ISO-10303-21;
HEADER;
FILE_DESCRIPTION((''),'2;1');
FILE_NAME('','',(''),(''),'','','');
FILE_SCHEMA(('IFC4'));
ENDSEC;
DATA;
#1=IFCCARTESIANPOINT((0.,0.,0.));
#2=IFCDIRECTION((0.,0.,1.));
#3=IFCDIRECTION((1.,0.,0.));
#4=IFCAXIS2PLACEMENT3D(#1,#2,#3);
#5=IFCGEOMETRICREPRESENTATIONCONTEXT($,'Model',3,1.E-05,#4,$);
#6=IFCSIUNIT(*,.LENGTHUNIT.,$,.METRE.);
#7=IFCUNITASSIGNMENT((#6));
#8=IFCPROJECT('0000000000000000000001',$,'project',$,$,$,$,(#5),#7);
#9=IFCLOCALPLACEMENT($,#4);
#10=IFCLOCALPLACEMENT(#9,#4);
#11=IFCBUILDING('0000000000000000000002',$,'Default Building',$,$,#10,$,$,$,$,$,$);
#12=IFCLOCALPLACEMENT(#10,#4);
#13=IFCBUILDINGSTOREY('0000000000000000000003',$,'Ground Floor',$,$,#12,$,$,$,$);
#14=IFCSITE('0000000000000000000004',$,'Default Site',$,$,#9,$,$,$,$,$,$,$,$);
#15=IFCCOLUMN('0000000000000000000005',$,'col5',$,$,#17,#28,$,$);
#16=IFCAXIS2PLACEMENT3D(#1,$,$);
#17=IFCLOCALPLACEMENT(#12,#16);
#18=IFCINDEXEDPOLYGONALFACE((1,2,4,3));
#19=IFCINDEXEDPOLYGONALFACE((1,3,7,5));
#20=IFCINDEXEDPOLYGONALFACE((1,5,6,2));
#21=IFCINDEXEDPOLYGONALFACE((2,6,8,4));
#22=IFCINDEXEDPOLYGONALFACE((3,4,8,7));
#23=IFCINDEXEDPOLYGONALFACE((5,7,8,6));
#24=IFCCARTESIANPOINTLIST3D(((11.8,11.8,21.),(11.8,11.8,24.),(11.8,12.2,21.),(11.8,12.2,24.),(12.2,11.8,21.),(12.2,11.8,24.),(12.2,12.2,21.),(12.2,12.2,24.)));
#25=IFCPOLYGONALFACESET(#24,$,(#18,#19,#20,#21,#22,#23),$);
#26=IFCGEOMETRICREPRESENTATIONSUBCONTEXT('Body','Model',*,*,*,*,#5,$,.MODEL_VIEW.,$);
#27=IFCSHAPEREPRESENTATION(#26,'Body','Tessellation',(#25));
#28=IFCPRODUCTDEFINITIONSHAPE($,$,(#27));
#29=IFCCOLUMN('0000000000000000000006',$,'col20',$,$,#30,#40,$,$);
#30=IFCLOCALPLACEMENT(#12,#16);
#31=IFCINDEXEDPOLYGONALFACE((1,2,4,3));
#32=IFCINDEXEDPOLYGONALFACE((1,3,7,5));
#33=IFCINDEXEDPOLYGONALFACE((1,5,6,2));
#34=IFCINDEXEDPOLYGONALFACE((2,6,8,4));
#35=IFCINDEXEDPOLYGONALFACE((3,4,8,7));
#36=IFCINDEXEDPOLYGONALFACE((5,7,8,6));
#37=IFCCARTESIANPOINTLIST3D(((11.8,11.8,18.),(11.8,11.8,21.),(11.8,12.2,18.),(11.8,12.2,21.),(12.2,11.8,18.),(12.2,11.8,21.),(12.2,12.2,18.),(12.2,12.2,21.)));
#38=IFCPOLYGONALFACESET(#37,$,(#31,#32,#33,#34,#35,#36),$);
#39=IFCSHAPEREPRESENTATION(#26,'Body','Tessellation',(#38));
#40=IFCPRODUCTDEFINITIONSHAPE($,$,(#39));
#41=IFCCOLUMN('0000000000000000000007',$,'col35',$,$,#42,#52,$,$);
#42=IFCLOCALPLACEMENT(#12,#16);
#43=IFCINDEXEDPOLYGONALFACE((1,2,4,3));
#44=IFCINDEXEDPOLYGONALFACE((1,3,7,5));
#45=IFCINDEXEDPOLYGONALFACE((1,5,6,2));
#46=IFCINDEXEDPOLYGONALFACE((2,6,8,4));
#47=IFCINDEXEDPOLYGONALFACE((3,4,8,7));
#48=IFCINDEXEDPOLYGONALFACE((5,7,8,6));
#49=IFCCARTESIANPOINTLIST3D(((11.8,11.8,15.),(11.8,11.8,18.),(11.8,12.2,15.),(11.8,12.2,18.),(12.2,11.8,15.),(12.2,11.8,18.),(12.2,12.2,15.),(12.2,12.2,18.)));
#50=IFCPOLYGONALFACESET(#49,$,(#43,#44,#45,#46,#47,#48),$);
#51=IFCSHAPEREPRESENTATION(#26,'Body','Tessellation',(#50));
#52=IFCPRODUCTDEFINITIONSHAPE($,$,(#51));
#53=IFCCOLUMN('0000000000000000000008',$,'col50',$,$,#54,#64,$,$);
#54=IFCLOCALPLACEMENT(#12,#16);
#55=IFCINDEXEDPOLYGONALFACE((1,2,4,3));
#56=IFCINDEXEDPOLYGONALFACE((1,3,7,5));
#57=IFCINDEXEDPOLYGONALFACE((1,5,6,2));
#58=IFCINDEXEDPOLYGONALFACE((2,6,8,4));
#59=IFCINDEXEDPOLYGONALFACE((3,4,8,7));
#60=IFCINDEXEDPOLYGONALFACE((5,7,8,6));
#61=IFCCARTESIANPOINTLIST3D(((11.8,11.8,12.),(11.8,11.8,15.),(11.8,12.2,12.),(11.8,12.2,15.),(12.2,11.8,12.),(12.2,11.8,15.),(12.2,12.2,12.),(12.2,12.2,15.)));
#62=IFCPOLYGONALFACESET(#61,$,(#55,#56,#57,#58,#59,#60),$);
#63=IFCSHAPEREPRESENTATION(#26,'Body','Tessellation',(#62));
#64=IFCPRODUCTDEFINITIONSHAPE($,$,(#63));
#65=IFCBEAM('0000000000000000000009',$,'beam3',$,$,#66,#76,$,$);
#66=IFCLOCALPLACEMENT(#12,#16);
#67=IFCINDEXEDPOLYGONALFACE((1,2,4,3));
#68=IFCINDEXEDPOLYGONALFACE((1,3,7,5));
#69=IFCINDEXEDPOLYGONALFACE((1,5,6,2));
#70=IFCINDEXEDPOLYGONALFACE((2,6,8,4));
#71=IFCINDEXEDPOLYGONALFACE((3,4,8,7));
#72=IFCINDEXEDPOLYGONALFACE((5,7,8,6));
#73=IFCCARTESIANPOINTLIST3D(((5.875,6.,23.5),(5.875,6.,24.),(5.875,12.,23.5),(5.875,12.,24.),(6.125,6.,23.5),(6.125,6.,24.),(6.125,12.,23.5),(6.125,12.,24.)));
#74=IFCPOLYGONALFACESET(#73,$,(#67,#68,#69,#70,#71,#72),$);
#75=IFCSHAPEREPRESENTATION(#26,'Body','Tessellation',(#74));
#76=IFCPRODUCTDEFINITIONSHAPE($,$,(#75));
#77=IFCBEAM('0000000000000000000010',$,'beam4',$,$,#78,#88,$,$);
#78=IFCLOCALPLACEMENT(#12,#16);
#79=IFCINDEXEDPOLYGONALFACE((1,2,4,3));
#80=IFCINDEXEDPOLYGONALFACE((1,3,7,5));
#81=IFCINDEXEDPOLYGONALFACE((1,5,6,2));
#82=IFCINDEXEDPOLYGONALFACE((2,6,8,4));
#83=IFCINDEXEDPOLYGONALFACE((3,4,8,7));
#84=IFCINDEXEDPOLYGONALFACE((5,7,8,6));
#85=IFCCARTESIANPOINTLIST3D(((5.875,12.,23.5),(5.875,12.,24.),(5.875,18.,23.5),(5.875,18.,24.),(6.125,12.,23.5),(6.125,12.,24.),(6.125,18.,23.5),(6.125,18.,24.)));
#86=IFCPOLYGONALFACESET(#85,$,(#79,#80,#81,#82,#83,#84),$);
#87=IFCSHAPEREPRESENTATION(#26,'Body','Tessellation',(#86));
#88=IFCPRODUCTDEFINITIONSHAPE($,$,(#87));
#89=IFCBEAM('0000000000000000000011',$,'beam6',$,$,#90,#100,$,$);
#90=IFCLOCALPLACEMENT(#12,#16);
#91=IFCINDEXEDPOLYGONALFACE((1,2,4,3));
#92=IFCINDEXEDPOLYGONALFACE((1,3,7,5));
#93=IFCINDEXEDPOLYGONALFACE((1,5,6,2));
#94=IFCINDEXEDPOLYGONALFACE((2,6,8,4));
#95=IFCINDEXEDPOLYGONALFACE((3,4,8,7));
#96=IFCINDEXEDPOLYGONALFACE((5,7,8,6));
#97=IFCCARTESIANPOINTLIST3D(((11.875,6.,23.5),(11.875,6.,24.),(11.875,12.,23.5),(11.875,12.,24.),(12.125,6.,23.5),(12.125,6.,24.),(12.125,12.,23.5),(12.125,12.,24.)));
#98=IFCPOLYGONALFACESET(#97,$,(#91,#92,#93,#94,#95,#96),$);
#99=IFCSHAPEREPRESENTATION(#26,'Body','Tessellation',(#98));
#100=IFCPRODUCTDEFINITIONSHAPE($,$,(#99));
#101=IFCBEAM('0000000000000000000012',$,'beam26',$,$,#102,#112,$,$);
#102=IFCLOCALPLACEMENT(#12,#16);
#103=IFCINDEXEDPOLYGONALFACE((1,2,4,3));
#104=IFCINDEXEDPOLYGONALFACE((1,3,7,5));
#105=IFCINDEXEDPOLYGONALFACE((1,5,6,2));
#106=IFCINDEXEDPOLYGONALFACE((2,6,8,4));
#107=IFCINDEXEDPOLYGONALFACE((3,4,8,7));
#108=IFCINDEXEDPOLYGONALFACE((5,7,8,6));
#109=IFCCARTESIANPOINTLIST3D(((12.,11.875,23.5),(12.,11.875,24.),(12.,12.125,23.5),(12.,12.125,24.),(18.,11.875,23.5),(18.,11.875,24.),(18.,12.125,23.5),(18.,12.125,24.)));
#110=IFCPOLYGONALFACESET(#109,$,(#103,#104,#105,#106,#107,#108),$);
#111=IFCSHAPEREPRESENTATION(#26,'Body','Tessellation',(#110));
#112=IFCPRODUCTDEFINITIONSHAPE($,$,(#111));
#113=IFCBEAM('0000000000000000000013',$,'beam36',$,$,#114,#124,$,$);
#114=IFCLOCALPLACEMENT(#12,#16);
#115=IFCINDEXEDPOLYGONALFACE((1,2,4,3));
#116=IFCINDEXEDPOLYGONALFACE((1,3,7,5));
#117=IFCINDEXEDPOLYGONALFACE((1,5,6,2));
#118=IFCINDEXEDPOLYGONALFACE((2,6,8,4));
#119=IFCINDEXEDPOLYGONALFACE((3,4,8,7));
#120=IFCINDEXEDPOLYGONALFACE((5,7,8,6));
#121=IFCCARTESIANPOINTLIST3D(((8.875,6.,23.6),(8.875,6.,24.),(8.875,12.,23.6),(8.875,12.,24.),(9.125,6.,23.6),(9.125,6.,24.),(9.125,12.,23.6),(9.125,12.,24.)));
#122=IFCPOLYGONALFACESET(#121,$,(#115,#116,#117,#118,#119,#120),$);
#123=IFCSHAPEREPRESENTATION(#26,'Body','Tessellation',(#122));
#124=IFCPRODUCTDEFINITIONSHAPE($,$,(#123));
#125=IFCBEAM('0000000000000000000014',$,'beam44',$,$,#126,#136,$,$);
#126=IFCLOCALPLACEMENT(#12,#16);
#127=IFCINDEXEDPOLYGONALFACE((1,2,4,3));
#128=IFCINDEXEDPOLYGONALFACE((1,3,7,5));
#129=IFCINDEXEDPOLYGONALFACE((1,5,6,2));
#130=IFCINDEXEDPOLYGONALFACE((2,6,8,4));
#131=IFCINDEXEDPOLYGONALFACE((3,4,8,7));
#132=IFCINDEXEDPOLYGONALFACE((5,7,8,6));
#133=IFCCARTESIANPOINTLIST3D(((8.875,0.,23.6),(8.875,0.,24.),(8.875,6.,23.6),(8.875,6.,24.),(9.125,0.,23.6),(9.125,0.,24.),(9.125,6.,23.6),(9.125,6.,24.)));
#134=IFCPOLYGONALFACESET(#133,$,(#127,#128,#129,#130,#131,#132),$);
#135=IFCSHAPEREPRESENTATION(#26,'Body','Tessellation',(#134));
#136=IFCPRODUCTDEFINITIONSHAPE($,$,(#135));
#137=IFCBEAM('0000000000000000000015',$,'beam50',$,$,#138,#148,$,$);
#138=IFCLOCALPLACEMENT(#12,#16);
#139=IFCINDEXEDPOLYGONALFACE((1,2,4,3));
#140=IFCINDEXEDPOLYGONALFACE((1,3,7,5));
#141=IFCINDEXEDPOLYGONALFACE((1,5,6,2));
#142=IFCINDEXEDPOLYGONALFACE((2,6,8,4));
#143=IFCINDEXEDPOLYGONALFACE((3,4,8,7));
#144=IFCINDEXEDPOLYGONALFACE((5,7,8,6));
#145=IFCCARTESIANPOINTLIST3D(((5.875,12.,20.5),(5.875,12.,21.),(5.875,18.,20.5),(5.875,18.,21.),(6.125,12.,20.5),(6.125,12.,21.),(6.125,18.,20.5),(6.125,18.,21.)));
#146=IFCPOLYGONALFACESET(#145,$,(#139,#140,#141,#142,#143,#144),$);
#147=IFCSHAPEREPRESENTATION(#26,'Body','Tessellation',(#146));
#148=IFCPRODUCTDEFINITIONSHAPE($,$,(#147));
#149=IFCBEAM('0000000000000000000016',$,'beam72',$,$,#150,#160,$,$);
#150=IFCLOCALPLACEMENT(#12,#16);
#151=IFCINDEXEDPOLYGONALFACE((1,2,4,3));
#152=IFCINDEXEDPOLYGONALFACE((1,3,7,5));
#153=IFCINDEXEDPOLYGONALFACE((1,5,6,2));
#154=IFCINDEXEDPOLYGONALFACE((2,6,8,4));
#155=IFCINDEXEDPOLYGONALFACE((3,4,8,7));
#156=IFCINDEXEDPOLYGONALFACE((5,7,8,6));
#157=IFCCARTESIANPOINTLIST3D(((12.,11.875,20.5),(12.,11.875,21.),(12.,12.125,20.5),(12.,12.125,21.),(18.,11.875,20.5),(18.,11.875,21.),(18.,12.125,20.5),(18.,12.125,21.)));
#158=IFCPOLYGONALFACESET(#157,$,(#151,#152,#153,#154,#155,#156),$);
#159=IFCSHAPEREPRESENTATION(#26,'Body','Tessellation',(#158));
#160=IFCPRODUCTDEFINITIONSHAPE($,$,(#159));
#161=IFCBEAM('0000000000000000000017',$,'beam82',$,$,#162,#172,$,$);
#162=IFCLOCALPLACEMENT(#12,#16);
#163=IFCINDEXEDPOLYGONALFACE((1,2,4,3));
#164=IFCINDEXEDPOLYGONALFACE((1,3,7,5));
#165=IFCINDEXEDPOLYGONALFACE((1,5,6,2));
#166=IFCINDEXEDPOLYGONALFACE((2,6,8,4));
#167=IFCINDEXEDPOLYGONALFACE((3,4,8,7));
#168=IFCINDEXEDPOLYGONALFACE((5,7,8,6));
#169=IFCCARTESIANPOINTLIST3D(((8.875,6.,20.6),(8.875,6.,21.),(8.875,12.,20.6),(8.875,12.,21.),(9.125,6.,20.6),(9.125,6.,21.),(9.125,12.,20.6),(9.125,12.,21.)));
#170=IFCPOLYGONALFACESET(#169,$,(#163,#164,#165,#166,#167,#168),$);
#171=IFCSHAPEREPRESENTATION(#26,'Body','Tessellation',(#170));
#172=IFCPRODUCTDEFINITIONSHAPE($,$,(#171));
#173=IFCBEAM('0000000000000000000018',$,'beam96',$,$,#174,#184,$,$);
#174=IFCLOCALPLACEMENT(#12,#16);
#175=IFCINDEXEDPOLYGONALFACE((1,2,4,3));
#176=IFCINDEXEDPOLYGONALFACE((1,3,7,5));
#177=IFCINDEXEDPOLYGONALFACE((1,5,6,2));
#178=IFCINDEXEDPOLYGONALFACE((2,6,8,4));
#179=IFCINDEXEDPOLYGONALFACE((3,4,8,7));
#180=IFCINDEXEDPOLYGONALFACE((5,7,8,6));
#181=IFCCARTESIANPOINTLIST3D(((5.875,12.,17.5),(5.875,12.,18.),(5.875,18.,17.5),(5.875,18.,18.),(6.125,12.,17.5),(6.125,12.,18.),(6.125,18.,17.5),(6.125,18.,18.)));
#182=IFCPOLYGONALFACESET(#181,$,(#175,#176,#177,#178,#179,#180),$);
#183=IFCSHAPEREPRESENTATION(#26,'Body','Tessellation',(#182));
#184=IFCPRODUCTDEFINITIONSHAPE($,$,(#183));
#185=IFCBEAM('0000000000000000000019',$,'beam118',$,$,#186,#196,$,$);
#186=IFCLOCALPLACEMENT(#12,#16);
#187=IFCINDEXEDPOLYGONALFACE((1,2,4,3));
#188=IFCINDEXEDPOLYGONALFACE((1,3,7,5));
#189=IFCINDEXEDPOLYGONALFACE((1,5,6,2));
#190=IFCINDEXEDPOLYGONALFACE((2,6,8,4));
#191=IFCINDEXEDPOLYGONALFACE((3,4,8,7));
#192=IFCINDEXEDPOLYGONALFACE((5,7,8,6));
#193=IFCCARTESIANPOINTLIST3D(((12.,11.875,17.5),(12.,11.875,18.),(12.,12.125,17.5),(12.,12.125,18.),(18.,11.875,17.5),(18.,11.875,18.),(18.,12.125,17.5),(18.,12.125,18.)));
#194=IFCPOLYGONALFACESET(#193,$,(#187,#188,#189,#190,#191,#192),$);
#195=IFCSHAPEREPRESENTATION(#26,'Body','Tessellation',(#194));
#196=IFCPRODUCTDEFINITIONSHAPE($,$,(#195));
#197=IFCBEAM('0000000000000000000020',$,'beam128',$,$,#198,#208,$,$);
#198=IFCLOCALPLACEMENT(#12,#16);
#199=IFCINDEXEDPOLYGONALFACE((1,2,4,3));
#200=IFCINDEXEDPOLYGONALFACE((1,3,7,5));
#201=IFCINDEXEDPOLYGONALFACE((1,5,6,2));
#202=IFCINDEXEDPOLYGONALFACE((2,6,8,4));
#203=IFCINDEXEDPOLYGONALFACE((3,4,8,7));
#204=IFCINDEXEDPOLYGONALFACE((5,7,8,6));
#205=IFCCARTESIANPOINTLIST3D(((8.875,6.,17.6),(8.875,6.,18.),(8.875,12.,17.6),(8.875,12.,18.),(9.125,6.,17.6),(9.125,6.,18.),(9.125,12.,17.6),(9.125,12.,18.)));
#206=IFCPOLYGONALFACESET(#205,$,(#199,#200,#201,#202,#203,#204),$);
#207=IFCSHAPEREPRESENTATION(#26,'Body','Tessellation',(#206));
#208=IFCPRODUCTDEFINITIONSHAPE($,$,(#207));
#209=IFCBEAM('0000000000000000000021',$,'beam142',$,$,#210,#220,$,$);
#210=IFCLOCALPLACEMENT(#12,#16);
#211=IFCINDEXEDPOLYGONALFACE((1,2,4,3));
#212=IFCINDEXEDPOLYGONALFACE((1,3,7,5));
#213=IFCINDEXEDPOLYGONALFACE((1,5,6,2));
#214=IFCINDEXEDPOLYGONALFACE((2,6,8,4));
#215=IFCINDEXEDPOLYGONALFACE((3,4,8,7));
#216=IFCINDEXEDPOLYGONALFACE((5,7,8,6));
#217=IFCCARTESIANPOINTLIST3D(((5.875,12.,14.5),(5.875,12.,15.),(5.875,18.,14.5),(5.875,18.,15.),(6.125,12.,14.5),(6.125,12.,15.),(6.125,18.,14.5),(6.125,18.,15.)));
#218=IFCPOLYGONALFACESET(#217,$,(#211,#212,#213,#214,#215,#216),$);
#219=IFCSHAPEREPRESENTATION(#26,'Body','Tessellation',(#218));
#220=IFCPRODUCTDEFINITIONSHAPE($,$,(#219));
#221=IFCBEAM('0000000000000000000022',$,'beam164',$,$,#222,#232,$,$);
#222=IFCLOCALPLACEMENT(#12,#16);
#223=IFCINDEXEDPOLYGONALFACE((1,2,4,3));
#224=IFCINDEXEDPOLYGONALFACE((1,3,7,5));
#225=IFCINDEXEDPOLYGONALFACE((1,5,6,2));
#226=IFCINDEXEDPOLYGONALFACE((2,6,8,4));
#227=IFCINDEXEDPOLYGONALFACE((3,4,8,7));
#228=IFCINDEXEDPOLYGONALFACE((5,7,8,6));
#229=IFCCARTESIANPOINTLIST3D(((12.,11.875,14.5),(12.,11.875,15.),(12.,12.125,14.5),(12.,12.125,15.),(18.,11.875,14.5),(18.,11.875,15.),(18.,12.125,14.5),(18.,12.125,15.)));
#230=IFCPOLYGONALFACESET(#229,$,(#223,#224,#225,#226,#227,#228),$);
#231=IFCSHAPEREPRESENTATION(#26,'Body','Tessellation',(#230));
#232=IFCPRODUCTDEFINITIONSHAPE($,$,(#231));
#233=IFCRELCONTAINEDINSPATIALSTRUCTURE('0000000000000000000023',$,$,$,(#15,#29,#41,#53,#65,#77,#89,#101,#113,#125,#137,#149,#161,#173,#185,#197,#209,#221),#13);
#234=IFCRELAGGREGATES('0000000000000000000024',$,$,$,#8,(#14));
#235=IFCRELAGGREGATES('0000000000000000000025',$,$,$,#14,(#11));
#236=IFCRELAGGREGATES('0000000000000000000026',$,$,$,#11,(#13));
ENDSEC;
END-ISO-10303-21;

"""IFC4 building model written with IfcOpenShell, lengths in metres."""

from ifc_helpers import new_model, si_unit, frame, origin_with_axes, place, context, subcontext, project, spatial, indexed_curve, outline, extrude, element, save


model = new_model("IFC4")

# Units and contexts
model_context = context("Model", 3, precision=1e-05, world=origin_with_axes())
body_context = subcontext(model_context, "Body", "Model", "MODEL_VIEW")
ifc_project = project(units=[si_unit("LENGTHUNIT", "METRE")], contexts=[model_context])

# Site, building, storey
site_placement = place(None, origin_with_axes())
site = spatial("IfcSite", under=ifc_project, at=site_placement, Name="Default Site")
building_placement = place(site_placement, origin_with_axes())
building = spatial("IfcBuilding", under=site, at=building_placement, Name="Default Building")
storey_placement = place(building_placement, origin_with_axes())
storey = spatial("IfcBuildingStorey", under=building, at=storey_placement, Name="Ground Floor")

# Columns
for number, where, z_axis, x_axis, name in (
    (1, (11.8, 11.8, 21.0), (0.0, 0.0, 1.0), (1.0, 0.0, 0.0), "col5"),
    (2, (11.8, 11.8, 18.0), (0.0, 0.0, 1.0), (1.0, 0.0, 0.0), "col20"),
    (3, (11.8, 11.8, 15.0), (0.0, 0.0, 1.0), (1.0, 0.0, 0.0), "col35"),
    (4, (11.8, 11.8, 12.0), (0.0, 0.0, 1.0), (1.0, 0.0, 0.0), "col50"),
):
    element("IfcColumn", number, at=place(storey_placement, frame(where, z_axis=z_axis, x_axis=x_axis)), inside=storey, Name=name, context=body_context, shape_type="SweptSolid", body=[
        extrude(outline(indexed_curve([(0.0, 0.0), (0.0, 0.4), (0.4, 0.4), (0.4, 0.0), (0.0, 0.0)], self_intersect=False)), origin_with_axes(), (0.0, 0.0, 1.0), 3.0),
    ])

# Beams
for number, where, z_axis, x_axis, name in (
    (5, (6.125, 6.0, 23.5), (0.0, 0.0, 1.0), (0.0, 1.0, 0.0), "beam3"),
    (6, (6.125, 12.0, 23.5), (0.0, 0.0, 1.0), (0.0, 1.0, 0.0), "beam4"),
    (7, (12.125, 6.0, 23.5), (0.0, 0.0, 1.0), (0.0, 1.0, 0.0), "beam6"),
    (8, (12.0, 11.875, 23.5), (0.0, 0.0, 1.0), (1.0, 0.0, 0.0), "beam26"),
):
    element("IfcBeam", number, at=place(storey_placement, frame(where, z_axis=z_axis, x_axis=x_axis)), inside=storey, Name=name, context=body_context, shape_type="SweptSolid", body=[
        extrude(outline(indexed_curve([(0.0, 0.0), (0.0, 0.25), (6.0, 0.25), (6.0, 0.0), (0.0, 0.0)], self_intersect=False)), origin_with_axes(), (0.0, 0.0, 1.0), 0.5),
    ])
for number, where, z_axis, x_axis, name in (
    (9, (8.875, 12.0, 23.6), (0.0, 0.0, 1.0), (0.0, -1.0, 0.0), "beam36"),
    (10, (8.875, 6.0, 23.6), (0.0, 0.0, 1.0), (0.0, -1.0, 0.0), "beam44"),
):
    element("IfcBeam", number, at=place(storey_placement, frame(where, z_axis=z_axis, x_axis=x_axis)), inside=storey, Name=name, context=body_context, shape_type="SweptSolid", body=[
        extrude(outline(indexed_curve([(0.0, 0.0), (0.0, 0.25), (6.0, 0.25), (6.0, 0.0), (0.0, 0.0)], self_intersect=False)), origin_with_axes(), (0.0, 0.0, 1.0), 0.4),
    ])
for number, where, z_axis, x_axis, name in (
    (11, (6.125, 12.0, 20.5), (0.0, 0.0, 1.0), (0.0, 1.0, 0.0), "beam50"),
    (12, (12.0, 11.875, 20.5), (0.0, 0.0, 1.0), (1.0, 0.0, 0.0), "beam72"),
):
    element("IfcBeam", number, at=place(storey_placement, frame(where, z_axis=z_axis, x_axis=x_axis)), inside=storey, Name=name, context=body_context, shape_type="SweptSolid", body=[
        extrude(outline(indexed_curve([(0.0, 0.0), (0.0, 0.25), (6.0, 0.25), (6.0, 0.0), (0.0, 0.0)], self_intersect=False)), origin_with_axes(), (0.0, 0.0, 1.0), 0.5),
    ])
beam_1_placement = place(storey_placement, frame((8.875, 12.0, 20.6), z_axis=(0.0, 0.0, 1.0), x_axis=(0.0, -1.0, 0.0)))
element("IfcBeam", 13, at=beam_1_placement, inside=storey, Name="beam82", context=body_context, shape_type="SweptSolid", body=[
    extrude(outline(indexed_curve([(0.0, 0.0), (0.0, 0.25), (6.0, 0.25), (6.0, 0.0), (0.0, 0.0)], self_intersect=False)), origin_with_axes(), (0.0, 0.0, 1.0), 0.4),
])
for number, where, z_axis, x_axis, name in (
    (14, (6.125, 12.0, 17.5), (0.0, 0.0, 1.0), (0.0, 1.0, 0.0), "beam96"),
    (15, (12.0, 11.875, 17.5), (0.0, 0.0, 1.0), (1.0, 0.0, 0.0), "beam118"),
):
    element("IfcBeam", number, at=place(storey_placement, frame(where, z_axis=z_axis, x_axis=x_axis)), inside=storey, Name=name, context=body_context, shape_type="SweptSolid", body=[
        extrude(outline(indexed_curve([(0.0, 0.0), (0.0, 0.25), (6.0, 0.25), (6.0, 0.0), (0.0, 0.0)], self_intersect=False)), origin_with_axes(), (0.0, 0.0, 1.0), 0.5),
    ])
beam_2_placement = place(storey_placement, frame((8.875, 12.0, 17.6), z_axis=(0.0, 0.0, 1.0), x_axis=(0.0, -1.0, 0.0)))
element("IfcBeam", 16, at=beam_2_placement, inside=storey, Name="beam128", context=body_context, shape_type="SweptSolid", body=[
    extrude(outline(indexed_curve([(0.0, 0.0), (0.0, 0.25), (6.0, 0.25), (6.0, 0.0), (0.0, 0.0)], self_intersect=False)), origin_with_axes(), (0.0, 0.0, 1.0), 0.4),
])
for number, where, z_axis, x_axis, name in (
    (17, (6.125, 12.0, 14.5), (0.0, 0.0, 1.0), (0.0, 1.0, 0.0), "beam142"),
    (18, (12.0, 11.875, 14.5), (0.0, 0.0, 1.0), (1.0, 0.0, 0.0), "beam164"),
):
    element("IfcBeam", number, at=place(storey_placement, frame(where, z_axis=z_axis, x_axis=x_axis)), inside=storey, Name=name, context=body_context, shape_type="SweptSolid", body=[
        extrude(outline(indexed_curve([(0.0, 0.0), (0.0, 0.25), (6.0, 0.25), (6.0, 0.0), (0.0, 0.0)], self_intersect=False)), origin_with_axes(), (0.0, 0.0, 1.0), 0.5),
    ])

save(model, "model.ifc")
